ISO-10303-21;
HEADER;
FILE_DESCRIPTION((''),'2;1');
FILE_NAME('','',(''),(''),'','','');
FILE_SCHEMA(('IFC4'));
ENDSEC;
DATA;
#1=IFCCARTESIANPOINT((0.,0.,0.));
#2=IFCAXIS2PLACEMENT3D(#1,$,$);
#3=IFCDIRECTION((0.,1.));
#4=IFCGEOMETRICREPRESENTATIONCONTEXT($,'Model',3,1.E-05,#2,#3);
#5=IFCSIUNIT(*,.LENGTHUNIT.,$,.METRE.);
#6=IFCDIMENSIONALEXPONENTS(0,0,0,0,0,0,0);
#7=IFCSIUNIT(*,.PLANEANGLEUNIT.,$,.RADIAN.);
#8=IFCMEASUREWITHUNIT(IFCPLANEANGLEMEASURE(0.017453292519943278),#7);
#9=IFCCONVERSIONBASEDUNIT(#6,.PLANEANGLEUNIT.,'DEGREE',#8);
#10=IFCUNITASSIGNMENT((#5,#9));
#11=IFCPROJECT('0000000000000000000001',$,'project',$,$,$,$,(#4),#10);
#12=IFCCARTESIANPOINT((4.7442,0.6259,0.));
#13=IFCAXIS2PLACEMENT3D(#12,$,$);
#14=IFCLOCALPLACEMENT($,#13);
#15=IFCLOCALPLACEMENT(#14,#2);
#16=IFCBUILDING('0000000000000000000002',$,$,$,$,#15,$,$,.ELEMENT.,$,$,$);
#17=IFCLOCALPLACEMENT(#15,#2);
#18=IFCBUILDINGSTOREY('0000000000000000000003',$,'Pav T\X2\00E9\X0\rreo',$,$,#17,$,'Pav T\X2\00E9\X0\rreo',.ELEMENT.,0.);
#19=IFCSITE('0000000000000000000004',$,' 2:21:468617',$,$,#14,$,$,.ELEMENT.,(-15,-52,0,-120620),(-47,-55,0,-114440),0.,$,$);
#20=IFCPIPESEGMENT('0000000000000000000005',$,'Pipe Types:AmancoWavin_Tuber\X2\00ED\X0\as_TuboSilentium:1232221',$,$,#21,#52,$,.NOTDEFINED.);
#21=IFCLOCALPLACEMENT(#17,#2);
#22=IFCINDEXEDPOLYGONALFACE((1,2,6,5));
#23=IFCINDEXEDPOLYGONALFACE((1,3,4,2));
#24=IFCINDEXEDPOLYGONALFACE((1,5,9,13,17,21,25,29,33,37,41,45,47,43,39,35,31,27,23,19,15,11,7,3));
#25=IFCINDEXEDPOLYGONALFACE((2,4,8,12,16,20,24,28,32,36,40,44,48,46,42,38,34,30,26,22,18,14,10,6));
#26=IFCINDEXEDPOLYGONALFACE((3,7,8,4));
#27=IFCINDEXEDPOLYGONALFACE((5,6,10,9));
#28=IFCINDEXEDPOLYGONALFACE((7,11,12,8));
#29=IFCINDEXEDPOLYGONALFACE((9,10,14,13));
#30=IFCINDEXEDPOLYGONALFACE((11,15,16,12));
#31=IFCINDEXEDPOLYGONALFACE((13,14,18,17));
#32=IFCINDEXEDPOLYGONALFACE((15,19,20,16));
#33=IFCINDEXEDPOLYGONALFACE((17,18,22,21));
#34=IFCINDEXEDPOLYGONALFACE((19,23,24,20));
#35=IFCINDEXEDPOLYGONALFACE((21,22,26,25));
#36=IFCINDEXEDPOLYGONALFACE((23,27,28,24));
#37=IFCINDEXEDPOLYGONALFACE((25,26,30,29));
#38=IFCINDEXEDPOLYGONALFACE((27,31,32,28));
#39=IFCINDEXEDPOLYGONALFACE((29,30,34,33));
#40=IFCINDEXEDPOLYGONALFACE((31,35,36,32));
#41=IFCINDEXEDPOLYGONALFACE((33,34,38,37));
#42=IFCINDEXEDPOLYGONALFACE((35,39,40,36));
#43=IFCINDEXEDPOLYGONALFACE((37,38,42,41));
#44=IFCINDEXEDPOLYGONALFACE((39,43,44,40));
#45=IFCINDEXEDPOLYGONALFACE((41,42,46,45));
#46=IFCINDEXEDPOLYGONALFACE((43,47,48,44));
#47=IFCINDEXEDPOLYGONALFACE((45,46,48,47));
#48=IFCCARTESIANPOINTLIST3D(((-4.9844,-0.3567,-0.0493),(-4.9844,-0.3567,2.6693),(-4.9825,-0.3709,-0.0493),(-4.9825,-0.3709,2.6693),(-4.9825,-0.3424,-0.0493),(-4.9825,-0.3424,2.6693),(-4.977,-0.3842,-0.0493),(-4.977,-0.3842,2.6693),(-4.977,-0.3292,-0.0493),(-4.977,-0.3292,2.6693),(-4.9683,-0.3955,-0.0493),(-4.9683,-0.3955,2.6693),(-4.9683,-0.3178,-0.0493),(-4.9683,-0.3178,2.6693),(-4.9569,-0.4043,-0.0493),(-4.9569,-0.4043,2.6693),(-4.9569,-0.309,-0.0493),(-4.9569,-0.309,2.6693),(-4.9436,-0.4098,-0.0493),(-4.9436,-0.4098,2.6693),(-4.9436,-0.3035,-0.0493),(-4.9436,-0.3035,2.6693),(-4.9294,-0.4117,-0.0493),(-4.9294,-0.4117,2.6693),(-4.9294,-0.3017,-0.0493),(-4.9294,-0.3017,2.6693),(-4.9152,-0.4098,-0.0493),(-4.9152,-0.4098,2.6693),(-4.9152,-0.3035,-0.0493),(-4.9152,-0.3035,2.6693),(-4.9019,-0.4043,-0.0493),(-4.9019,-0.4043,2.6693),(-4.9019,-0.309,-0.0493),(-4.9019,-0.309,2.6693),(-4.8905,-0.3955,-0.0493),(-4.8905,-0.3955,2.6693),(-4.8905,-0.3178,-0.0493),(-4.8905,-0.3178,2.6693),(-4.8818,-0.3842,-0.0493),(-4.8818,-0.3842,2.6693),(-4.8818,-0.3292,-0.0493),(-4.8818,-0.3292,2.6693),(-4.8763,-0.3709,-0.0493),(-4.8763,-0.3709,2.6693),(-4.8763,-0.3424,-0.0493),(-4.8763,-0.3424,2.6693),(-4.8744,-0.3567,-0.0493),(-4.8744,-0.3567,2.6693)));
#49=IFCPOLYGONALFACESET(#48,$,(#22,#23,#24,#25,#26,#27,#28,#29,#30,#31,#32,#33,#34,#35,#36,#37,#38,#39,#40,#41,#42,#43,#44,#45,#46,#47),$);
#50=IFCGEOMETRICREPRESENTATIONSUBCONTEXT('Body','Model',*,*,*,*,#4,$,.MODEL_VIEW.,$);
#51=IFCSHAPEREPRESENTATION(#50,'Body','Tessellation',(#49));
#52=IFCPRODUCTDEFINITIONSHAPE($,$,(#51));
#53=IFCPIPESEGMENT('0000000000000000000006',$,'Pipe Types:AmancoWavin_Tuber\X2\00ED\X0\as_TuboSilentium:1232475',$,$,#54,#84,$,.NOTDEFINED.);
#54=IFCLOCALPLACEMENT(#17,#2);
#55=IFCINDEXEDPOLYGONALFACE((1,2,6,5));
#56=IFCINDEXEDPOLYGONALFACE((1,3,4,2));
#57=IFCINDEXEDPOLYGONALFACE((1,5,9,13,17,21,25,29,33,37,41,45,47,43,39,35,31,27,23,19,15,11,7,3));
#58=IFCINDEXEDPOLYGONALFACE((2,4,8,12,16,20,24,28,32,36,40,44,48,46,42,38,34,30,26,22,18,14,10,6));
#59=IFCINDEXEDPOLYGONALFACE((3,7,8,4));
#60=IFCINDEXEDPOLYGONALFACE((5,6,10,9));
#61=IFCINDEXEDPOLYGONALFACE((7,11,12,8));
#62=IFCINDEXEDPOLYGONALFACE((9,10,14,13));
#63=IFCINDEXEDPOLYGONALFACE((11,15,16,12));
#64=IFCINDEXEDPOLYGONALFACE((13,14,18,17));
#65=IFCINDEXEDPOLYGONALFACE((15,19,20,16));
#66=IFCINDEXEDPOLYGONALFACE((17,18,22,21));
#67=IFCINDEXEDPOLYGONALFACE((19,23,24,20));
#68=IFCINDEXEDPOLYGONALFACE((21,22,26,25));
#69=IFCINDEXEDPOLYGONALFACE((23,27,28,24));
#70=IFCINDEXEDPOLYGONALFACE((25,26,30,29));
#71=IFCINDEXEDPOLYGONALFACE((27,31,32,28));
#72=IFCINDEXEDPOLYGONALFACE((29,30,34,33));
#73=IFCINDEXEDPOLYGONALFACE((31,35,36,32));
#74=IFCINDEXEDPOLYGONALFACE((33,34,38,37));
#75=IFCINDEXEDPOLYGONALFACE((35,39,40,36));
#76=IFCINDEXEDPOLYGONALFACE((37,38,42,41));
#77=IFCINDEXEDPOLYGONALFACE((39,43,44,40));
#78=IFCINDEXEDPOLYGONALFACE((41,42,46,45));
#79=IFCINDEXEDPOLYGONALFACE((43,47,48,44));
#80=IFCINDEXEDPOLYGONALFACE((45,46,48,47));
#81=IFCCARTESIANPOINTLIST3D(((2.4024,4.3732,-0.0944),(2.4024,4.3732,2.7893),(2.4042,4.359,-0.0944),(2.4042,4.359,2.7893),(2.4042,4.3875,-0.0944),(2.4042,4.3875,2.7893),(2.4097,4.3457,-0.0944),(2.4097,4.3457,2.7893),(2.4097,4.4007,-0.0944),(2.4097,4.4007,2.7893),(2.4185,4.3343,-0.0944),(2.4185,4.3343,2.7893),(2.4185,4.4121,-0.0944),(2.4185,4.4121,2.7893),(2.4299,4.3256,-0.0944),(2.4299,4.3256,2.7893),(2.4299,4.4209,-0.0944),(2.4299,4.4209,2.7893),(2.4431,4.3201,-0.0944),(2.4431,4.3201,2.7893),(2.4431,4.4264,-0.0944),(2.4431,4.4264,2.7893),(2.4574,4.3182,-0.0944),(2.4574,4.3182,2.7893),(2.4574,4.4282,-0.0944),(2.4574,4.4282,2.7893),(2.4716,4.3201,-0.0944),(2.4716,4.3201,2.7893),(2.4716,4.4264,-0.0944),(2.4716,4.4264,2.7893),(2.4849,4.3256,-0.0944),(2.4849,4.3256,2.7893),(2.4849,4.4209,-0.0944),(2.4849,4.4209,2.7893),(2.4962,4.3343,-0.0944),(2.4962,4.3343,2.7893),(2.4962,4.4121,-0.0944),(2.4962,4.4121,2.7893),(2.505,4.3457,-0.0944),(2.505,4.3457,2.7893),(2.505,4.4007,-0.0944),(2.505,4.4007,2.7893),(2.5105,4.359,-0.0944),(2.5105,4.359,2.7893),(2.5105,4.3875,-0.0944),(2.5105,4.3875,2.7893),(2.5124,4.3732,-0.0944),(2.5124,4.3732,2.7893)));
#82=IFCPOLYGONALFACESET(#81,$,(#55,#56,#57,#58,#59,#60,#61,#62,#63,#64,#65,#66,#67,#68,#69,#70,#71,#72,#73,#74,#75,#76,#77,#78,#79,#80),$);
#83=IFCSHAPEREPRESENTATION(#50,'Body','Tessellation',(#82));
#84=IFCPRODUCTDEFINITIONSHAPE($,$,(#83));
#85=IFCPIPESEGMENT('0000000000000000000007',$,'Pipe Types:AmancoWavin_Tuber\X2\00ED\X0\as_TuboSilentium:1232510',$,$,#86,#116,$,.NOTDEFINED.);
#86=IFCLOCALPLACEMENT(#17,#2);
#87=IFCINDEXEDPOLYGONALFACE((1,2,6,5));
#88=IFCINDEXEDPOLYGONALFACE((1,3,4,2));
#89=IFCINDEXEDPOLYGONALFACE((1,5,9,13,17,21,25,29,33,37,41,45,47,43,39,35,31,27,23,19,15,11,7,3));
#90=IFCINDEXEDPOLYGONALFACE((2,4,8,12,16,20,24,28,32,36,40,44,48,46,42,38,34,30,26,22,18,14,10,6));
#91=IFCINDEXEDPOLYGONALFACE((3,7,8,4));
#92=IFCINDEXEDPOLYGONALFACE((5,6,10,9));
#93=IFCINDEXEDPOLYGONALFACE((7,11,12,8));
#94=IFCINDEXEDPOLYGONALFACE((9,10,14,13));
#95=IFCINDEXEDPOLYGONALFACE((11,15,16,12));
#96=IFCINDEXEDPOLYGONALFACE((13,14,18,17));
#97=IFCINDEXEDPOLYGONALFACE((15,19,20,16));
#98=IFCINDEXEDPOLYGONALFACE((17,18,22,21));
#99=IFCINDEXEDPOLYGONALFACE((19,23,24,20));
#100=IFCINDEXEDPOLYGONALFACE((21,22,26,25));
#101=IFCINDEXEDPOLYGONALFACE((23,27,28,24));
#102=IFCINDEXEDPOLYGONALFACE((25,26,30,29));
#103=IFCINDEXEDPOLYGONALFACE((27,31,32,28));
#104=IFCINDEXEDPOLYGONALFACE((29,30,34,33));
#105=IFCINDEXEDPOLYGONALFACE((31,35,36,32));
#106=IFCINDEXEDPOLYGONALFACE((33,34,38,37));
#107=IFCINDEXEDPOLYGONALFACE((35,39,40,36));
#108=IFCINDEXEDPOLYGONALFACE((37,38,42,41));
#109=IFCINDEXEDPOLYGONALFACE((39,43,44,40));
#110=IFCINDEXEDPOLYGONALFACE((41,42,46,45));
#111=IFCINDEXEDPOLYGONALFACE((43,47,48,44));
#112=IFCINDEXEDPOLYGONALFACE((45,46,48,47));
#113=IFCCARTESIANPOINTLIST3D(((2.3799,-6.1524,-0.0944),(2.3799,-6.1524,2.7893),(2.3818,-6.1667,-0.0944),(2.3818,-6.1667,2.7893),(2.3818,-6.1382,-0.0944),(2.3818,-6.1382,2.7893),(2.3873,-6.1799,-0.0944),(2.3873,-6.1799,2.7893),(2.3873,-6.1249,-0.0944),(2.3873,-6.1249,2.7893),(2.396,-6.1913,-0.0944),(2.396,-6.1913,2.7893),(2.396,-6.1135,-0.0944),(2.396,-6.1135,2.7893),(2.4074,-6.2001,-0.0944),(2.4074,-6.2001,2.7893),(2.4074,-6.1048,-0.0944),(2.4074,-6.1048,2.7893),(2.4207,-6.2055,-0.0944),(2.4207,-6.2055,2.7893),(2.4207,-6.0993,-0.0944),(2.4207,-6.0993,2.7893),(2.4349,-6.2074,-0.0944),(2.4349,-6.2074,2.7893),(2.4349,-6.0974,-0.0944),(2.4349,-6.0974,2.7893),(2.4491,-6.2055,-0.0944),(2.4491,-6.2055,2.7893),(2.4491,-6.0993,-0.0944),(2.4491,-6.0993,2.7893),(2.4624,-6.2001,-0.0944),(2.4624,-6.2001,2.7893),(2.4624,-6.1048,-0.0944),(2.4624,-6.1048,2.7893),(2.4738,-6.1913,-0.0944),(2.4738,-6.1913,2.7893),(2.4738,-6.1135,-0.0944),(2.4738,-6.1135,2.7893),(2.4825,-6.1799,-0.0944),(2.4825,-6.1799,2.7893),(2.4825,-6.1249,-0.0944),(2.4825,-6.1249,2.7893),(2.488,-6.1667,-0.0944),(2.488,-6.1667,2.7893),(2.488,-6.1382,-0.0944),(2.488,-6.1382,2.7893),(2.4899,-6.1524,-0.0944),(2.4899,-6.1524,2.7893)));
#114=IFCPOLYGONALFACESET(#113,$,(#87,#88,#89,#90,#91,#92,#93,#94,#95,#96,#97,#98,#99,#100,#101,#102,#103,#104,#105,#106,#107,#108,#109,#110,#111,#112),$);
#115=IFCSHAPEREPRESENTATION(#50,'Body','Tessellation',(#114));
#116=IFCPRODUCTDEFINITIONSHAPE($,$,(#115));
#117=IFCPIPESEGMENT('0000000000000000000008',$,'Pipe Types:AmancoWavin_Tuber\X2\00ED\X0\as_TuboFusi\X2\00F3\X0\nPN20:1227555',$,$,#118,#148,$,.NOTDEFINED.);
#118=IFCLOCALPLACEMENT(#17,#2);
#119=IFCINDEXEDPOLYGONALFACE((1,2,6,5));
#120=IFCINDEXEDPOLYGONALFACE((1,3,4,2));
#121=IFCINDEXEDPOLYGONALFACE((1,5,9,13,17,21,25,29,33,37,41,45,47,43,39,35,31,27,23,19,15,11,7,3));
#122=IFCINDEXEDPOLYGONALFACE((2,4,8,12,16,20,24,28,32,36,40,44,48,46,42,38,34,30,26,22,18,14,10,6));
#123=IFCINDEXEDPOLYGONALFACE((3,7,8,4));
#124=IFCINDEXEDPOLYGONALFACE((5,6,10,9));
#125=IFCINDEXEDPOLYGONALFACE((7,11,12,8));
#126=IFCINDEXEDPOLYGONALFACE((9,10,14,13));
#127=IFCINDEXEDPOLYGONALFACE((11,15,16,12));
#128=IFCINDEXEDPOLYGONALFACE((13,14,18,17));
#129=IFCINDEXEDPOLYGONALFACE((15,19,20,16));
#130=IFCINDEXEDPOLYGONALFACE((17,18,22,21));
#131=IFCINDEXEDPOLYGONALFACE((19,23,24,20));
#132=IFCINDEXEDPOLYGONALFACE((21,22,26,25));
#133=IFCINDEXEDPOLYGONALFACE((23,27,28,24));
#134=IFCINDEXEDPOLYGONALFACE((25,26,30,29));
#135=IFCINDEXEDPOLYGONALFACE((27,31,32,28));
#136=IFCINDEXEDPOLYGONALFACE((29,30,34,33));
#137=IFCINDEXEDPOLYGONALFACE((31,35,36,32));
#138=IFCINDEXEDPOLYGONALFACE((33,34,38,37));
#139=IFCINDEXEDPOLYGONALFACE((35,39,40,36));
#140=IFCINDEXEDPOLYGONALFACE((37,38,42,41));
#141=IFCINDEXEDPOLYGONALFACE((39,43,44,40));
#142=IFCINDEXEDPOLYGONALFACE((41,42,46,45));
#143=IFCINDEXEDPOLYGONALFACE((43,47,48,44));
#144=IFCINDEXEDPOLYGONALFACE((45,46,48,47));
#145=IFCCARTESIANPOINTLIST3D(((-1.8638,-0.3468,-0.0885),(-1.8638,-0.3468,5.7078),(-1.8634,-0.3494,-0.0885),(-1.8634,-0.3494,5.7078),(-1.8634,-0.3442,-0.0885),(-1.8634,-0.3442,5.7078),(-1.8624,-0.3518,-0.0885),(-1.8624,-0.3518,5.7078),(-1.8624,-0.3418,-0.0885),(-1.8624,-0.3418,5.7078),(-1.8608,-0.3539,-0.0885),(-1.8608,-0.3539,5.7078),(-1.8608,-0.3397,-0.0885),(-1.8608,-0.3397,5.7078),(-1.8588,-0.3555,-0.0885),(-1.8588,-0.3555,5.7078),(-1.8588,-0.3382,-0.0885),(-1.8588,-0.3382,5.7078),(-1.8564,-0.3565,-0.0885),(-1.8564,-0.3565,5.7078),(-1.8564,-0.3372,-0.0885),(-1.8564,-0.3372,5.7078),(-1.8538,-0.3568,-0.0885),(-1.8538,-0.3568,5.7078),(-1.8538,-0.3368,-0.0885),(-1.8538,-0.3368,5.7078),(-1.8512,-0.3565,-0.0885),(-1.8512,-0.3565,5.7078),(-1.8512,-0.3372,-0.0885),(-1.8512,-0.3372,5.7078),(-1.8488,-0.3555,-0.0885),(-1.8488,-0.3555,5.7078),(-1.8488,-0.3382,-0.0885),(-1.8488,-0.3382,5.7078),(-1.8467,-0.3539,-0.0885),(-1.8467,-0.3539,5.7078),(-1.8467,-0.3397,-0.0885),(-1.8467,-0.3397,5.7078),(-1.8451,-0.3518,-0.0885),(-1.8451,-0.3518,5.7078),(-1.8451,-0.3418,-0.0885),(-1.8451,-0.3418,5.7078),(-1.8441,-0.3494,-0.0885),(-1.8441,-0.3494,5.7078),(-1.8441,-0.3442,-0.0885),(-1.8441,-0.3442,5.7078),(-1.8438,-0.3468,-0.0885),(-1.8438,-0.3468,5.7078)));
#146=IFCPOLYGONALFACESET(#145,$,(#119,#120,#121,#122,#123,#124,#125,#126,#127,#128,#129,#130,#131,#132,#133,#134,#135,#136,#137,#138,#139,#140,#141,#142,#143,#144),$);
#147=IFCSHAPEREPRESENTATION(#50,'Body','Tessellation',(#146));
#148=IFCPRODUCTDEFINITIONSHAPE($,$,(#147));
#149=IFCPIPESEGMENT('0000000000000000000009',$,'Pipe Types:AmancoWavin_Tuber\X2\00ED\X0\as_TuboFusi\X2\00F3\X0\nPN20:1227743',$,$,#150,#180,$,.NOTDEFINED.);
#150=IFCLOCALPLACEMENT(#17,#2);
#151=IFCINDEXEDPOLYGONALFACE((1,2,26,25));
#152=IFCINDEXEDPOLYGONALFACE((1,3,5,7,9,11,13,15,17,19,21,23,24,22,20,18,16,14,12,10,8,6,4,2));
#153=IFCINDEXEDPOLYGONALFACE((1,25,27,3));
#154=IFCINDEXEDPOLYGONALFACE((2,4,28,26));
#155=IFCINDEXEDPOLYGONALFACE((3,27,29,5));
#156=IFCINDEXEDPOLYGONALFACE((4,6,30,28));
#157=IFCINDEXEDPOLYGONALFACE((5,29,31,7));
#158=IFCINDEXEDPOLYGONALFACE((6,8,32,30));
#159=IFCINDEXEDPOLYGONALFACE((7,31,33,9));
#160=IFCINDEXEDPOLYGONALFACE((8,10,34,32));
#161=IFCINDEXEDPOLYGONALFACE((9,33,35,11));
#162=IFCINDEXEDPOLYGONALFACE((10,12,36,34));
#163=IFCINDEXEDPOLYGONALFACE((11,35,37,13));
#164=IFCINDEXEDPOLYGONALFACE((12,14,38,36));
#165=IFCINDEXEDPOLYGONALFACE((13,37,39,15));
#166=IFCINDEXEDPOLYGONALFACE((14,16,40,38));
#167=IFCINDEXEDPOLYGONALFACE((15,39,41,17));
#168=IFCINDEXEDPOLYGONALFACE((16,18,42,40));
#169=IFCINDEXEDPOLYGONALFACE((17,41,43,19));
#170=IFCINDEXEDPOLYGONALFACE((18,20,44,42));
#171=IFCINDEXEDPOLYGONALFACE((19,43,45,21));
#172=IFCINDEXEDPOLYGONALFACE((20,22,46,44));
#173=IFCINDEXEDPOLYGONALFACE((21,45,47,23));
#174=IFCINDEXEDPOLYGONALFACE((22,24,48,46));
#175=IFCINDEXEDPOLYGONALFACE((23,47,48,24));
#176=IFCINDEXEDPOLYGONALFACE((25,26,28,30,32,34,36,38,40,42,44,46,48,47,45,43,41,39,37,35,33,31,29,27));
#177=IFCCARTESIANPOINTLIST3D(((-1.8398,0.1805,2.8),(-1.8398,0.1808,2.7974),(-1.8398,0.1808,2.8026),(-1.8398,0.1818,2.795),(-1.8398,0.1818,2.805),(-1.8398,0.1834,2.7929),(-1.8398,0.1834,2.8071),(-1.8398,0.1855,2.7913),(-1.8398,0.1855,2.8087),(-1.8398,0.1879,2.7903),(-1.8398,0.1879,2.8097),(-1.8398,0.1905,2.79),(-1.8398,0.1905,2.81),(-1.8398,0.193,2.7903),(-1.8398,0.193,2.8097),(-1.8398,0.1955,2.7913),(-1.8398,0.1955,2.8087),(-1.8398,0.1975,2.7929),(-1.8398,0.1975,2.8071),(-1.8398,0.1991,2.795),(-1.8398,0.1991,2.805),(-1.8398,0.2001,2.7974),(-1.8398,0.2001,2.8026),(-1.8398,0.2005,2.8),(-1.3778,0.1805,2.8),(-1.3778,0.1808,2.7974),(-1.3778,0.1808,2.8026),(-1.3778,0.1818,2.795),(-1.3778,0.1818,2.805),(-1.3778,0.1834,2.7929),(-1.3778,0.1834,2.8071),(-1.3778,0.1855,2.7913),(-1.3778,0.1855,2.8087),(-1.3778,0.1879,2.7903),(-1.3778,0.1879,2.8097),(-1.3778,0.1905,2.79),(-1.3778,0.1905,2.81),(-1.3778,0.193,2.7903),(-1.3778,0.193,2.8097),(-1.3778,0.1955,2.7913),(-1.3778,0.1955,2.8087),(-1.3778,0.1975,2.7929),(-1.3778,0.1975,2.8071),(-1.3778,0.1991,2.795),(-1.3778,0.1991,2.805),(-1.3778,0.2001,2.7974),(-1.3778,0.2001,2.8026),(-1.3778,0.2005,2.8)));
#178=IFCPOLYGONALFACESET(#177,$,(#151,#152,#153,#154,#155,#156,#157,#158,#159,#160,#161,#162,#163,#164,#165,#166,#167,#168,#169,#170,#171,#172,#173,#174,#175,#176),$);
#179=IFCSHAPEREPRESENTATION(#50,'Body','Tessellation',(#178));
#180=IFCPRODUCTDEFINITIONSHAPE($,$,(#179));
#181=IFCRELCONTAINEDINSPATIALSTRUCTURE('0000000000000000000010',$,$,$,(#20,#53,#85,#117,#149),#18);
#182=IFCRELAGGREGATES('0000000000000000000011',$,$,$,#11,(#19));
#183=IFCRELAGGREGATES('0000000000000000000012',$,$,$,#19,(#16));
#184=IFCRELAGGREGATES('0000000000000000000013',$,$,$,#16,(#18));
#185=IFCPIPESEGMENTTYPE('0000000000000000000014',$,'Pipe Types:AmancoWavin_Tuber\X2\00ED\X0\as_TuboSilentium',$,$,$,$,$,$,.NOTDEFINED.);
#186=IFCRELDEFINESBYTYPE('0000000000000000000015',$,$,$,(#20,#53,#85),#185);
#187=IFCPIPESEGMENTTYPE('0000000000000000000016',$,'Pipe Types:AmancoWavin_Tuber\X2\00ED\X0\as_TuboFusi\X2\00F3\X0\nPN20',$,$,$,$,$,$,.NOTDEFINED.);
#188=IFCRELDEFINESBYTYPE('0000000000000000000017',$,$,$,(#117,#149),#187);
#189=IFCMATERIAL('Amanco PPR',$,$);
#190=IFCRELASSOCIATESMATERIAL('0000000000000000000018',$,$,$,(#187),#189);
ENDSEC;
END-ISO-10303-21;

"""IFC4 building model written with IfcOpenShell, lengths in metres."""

from ifc_helpers import new_model, entity, si_unit, converted_unit, direction, frame, origin, place, context, subcontext, project, spatial, arc, indexed_curve, outline, extrude, material, type_object, element, save


model = new_model("IFC4")

# Units and contexts
model_context = context("Model", 3, precision=1e-05, world=origin(), true_north=direction((0.0, 1.0)))
body_context = subcontext(model_context, "Body", "Model", "MODEL_VIEW")
ifc_project = project(units=[si_unit("LENGTHUNIT", "METRE"), converted_unit("PLANEANGLEUNIT", "DEGREE", entity("IfcPlaneAngleMeasure", 0.017453292519943278), si_unit("PLANEANGLEUNIT", "RADIAN"), dimensions=[0, 0, 0, 0, 0, 0, 0])], contexts=[model_context])

# Site, building, storey
site_placement = place(None, frame((4.7442, 0.6259, 0.0)))
site = spatial("IfcSite", under=ifc_project, at=site_placement, Name=" 2:21:468617", CompositionType="ELEMENT", RefLatitude=(-15, -52, 0, -120620), RefLongitude=(-47, -55, 0, -114440), RefElevation=0.0)
building_placement = place(site_placement, origin())
building = spatial("IfcBuilding", under=site, at=building_placement, CompositionType="ELEMENT")
storey_placement = place(building_placement, origin())
storey = spatial("IfcBuildingStorey", under=building, at=storey_placement, Name="Pav Térreo", LongName="Pav Térreo", CompositionType="ELEMENT", Elevation=0.0)

# Pipe segments
pipe_segment_type_1 = type_object("IfcPipeSegmentType", Name="Pipe Types:AmancoWavin_Tuberías_TuboSilentium", PredefinedType="NOTDEFINED")
pipe_segment_1_placement = place(storey_placement, origin())
element("IfcPipeSegment", 1, at=pipe_segment_1_placement, inside=storey, type_object=pipe_segment_type_1, Name="Pipe Types:AmancoWavin_Tuberías_TuboSilentium:1232221", PredefinedType="NOTDEFINED", context=body_context, shape_type="SweptSolid", body=[
    extrude(outline(indexed_curve([(0.055, 0.0), (0.0389, 0.0389), (0.0, 0.055), (-0.0389, 0.0389), (-0.055, 0.0), (-0.0389, -0.0389), (0.0, -0.055), (0.0389, -0.0389)], segments=[arc(1, 2, 3), arc(3, 4, 5), arc(5, 6, 7), arc(7, 8, 1)], self_intersect=False)), frame((-4.9294, -0.3567, -0.0493), z_axis=(0.0, 0.0, 1.0), x_axis=(-1.0, 0.0, 0.0)), (0.0, 0.0, 1.0), 2.7186),
])
pipe_segment_2_placement = place(storey_placement, origin())
element("IfcPipeSegment", 2, at=pipe_segment_2_placement, inside=storey, type_object=pipe_segment_type_1, Name="Pipe Types:AmancoWavin_Tuberías_TuboSilentium:1232475", PredefinedType="NOTDEFINED", context=body_context, shape_type="SweptSolid", body=[
    extrude(outline(indexed_curve([(0.055, 0.0), (0.0389, 0.0389), (0.0, 0.055), (-0.0389, 0.0389), (-0.055, 0.0), (-0.0389, -0.0389), (0.0, -0.055), (0.0389, -0.0389)], segments=[arc(1, 2, 3), arc(3, 4, 5), arc(5, 6, 7), arc(7, 8, 1)], self_intersect=False)), frame((2.4574, 4.3732, -0.0944), z_axis=(0.0, 0.0, 1.0), x_axis=(-1.0, 0.0, 0.0)), (0.0, 0.0, 1.0), 2.8837),
])
pipe_segment_3_placement = place(storey_placement, origin())
element("IfcPipeSegment", 3, at=pipe_segment_3_placement, inside=storey, type_object=pipe_segment_type_1, Name="Pipe Types:AmancoWavin_Tuberías_TuboSilentium:1232510", PredefinedType="NOTDEFINED", context=body_context, shape_type="SweptSolid", body=[
    extrude(outline(indexed_curve([(0.055, 0.0), (0.0389, 0.0389), (0.0, 0.055), (-0.0389, 0.0389), (-0.055, 0.0), (-0.0389, -0.0389), (0.0, -0.055), (0.0389, -0.0389)], segments=[arc(1, 2, 3), arc(3, 4, 5), arc(5, 6, 7), arc(7, 8, 1)], self_intersect=False)), frame((2.4349, -6.1524, -0.0944), z_axis=(0.0, 0.0, 1.0), x_axis=(-1.0, 0.0, 0.0)), (0.0, 0.0, 1.0), 2.8837),
])
ifc_material_1 = material(Name="Amanco PPR")
pipe_segment_type_2 = type_object("IfcPipeSegmentType", Name="Pipe Types:AmancoWavin_Tuberías_TuboFusiónPN20", PredefinedType="NOTDEFINED", material=ifc_material_1)
pipe_segment_4_placement = place(storey_placement, origin())
element("IfcPipeSegment", 4, at=pipe_segment_4_placement, inside=storey, type_object=pipe_segment_type_2, Name="Pipe Types:AmancoWavin_Tuberías_TuboFusiónPN20:1227555", PredefinedType="NOTDEFINED", context=body_context, shape_type="SweptSolid", body=[
    extrude(outline(indexed_curve([(0.01, 0.0), (0.0071, 0.0071), (0.0, 0.01), (-0.0071, 0.0071), (-0.01, 0.0), (-0.0071, -0.0071), (0.0, -0.01), (0.0071, -0.0071)], segments=[arc(1, 2, 3), arc(3, 4, 5), arc(5, 6, 7), arc(7, 8, 1)], self_intersect=False)), frame((-1.8538, -0.3468, -0.0885), z_axis=(0.0, 0.0, 1.0), x_axis=(-1.0, 0.0, 0.0)), (0.0, 0.0, 1.0), 5.7963),
])
pipe_segment_5_placement = place(storey_placement, origin())
element("IfcPipeSegment", 5, at=pipe_segment_5_placement, inside=storey, type_object=pipe_segment_type_2, Name="Pipe Types:AmancoWavin_Tuberías_TuboFusiónPN20:1227743", PredefinedType="NOTDEFINED", context=body_context, shape_type="SweptSolid", body=[
    extrude(outline(indexed_curve([(0.01, 0.0), (0.0071, 0.0071), (0.0, 0.01), (-0.0071, 0.0071), (-0.01, 0.0), (-0.0071, -0.0071), (0.0, -0.01), (0.0071, -0.0071)], segments=[arc(1, 2, 3), arc(3, 4, 5), arc(5, 6, 7), arc(7, 8, 1)], self_intersect=False)), frame((-1.8398, 0.1905, 2.8), z_axis=(1.0, 0.0, 0.0), x_axis=(0.0, -1.0, 0.0)), (0.0, 0.0, 1.0), 0.462),
])

save(model, "model.ifc")
